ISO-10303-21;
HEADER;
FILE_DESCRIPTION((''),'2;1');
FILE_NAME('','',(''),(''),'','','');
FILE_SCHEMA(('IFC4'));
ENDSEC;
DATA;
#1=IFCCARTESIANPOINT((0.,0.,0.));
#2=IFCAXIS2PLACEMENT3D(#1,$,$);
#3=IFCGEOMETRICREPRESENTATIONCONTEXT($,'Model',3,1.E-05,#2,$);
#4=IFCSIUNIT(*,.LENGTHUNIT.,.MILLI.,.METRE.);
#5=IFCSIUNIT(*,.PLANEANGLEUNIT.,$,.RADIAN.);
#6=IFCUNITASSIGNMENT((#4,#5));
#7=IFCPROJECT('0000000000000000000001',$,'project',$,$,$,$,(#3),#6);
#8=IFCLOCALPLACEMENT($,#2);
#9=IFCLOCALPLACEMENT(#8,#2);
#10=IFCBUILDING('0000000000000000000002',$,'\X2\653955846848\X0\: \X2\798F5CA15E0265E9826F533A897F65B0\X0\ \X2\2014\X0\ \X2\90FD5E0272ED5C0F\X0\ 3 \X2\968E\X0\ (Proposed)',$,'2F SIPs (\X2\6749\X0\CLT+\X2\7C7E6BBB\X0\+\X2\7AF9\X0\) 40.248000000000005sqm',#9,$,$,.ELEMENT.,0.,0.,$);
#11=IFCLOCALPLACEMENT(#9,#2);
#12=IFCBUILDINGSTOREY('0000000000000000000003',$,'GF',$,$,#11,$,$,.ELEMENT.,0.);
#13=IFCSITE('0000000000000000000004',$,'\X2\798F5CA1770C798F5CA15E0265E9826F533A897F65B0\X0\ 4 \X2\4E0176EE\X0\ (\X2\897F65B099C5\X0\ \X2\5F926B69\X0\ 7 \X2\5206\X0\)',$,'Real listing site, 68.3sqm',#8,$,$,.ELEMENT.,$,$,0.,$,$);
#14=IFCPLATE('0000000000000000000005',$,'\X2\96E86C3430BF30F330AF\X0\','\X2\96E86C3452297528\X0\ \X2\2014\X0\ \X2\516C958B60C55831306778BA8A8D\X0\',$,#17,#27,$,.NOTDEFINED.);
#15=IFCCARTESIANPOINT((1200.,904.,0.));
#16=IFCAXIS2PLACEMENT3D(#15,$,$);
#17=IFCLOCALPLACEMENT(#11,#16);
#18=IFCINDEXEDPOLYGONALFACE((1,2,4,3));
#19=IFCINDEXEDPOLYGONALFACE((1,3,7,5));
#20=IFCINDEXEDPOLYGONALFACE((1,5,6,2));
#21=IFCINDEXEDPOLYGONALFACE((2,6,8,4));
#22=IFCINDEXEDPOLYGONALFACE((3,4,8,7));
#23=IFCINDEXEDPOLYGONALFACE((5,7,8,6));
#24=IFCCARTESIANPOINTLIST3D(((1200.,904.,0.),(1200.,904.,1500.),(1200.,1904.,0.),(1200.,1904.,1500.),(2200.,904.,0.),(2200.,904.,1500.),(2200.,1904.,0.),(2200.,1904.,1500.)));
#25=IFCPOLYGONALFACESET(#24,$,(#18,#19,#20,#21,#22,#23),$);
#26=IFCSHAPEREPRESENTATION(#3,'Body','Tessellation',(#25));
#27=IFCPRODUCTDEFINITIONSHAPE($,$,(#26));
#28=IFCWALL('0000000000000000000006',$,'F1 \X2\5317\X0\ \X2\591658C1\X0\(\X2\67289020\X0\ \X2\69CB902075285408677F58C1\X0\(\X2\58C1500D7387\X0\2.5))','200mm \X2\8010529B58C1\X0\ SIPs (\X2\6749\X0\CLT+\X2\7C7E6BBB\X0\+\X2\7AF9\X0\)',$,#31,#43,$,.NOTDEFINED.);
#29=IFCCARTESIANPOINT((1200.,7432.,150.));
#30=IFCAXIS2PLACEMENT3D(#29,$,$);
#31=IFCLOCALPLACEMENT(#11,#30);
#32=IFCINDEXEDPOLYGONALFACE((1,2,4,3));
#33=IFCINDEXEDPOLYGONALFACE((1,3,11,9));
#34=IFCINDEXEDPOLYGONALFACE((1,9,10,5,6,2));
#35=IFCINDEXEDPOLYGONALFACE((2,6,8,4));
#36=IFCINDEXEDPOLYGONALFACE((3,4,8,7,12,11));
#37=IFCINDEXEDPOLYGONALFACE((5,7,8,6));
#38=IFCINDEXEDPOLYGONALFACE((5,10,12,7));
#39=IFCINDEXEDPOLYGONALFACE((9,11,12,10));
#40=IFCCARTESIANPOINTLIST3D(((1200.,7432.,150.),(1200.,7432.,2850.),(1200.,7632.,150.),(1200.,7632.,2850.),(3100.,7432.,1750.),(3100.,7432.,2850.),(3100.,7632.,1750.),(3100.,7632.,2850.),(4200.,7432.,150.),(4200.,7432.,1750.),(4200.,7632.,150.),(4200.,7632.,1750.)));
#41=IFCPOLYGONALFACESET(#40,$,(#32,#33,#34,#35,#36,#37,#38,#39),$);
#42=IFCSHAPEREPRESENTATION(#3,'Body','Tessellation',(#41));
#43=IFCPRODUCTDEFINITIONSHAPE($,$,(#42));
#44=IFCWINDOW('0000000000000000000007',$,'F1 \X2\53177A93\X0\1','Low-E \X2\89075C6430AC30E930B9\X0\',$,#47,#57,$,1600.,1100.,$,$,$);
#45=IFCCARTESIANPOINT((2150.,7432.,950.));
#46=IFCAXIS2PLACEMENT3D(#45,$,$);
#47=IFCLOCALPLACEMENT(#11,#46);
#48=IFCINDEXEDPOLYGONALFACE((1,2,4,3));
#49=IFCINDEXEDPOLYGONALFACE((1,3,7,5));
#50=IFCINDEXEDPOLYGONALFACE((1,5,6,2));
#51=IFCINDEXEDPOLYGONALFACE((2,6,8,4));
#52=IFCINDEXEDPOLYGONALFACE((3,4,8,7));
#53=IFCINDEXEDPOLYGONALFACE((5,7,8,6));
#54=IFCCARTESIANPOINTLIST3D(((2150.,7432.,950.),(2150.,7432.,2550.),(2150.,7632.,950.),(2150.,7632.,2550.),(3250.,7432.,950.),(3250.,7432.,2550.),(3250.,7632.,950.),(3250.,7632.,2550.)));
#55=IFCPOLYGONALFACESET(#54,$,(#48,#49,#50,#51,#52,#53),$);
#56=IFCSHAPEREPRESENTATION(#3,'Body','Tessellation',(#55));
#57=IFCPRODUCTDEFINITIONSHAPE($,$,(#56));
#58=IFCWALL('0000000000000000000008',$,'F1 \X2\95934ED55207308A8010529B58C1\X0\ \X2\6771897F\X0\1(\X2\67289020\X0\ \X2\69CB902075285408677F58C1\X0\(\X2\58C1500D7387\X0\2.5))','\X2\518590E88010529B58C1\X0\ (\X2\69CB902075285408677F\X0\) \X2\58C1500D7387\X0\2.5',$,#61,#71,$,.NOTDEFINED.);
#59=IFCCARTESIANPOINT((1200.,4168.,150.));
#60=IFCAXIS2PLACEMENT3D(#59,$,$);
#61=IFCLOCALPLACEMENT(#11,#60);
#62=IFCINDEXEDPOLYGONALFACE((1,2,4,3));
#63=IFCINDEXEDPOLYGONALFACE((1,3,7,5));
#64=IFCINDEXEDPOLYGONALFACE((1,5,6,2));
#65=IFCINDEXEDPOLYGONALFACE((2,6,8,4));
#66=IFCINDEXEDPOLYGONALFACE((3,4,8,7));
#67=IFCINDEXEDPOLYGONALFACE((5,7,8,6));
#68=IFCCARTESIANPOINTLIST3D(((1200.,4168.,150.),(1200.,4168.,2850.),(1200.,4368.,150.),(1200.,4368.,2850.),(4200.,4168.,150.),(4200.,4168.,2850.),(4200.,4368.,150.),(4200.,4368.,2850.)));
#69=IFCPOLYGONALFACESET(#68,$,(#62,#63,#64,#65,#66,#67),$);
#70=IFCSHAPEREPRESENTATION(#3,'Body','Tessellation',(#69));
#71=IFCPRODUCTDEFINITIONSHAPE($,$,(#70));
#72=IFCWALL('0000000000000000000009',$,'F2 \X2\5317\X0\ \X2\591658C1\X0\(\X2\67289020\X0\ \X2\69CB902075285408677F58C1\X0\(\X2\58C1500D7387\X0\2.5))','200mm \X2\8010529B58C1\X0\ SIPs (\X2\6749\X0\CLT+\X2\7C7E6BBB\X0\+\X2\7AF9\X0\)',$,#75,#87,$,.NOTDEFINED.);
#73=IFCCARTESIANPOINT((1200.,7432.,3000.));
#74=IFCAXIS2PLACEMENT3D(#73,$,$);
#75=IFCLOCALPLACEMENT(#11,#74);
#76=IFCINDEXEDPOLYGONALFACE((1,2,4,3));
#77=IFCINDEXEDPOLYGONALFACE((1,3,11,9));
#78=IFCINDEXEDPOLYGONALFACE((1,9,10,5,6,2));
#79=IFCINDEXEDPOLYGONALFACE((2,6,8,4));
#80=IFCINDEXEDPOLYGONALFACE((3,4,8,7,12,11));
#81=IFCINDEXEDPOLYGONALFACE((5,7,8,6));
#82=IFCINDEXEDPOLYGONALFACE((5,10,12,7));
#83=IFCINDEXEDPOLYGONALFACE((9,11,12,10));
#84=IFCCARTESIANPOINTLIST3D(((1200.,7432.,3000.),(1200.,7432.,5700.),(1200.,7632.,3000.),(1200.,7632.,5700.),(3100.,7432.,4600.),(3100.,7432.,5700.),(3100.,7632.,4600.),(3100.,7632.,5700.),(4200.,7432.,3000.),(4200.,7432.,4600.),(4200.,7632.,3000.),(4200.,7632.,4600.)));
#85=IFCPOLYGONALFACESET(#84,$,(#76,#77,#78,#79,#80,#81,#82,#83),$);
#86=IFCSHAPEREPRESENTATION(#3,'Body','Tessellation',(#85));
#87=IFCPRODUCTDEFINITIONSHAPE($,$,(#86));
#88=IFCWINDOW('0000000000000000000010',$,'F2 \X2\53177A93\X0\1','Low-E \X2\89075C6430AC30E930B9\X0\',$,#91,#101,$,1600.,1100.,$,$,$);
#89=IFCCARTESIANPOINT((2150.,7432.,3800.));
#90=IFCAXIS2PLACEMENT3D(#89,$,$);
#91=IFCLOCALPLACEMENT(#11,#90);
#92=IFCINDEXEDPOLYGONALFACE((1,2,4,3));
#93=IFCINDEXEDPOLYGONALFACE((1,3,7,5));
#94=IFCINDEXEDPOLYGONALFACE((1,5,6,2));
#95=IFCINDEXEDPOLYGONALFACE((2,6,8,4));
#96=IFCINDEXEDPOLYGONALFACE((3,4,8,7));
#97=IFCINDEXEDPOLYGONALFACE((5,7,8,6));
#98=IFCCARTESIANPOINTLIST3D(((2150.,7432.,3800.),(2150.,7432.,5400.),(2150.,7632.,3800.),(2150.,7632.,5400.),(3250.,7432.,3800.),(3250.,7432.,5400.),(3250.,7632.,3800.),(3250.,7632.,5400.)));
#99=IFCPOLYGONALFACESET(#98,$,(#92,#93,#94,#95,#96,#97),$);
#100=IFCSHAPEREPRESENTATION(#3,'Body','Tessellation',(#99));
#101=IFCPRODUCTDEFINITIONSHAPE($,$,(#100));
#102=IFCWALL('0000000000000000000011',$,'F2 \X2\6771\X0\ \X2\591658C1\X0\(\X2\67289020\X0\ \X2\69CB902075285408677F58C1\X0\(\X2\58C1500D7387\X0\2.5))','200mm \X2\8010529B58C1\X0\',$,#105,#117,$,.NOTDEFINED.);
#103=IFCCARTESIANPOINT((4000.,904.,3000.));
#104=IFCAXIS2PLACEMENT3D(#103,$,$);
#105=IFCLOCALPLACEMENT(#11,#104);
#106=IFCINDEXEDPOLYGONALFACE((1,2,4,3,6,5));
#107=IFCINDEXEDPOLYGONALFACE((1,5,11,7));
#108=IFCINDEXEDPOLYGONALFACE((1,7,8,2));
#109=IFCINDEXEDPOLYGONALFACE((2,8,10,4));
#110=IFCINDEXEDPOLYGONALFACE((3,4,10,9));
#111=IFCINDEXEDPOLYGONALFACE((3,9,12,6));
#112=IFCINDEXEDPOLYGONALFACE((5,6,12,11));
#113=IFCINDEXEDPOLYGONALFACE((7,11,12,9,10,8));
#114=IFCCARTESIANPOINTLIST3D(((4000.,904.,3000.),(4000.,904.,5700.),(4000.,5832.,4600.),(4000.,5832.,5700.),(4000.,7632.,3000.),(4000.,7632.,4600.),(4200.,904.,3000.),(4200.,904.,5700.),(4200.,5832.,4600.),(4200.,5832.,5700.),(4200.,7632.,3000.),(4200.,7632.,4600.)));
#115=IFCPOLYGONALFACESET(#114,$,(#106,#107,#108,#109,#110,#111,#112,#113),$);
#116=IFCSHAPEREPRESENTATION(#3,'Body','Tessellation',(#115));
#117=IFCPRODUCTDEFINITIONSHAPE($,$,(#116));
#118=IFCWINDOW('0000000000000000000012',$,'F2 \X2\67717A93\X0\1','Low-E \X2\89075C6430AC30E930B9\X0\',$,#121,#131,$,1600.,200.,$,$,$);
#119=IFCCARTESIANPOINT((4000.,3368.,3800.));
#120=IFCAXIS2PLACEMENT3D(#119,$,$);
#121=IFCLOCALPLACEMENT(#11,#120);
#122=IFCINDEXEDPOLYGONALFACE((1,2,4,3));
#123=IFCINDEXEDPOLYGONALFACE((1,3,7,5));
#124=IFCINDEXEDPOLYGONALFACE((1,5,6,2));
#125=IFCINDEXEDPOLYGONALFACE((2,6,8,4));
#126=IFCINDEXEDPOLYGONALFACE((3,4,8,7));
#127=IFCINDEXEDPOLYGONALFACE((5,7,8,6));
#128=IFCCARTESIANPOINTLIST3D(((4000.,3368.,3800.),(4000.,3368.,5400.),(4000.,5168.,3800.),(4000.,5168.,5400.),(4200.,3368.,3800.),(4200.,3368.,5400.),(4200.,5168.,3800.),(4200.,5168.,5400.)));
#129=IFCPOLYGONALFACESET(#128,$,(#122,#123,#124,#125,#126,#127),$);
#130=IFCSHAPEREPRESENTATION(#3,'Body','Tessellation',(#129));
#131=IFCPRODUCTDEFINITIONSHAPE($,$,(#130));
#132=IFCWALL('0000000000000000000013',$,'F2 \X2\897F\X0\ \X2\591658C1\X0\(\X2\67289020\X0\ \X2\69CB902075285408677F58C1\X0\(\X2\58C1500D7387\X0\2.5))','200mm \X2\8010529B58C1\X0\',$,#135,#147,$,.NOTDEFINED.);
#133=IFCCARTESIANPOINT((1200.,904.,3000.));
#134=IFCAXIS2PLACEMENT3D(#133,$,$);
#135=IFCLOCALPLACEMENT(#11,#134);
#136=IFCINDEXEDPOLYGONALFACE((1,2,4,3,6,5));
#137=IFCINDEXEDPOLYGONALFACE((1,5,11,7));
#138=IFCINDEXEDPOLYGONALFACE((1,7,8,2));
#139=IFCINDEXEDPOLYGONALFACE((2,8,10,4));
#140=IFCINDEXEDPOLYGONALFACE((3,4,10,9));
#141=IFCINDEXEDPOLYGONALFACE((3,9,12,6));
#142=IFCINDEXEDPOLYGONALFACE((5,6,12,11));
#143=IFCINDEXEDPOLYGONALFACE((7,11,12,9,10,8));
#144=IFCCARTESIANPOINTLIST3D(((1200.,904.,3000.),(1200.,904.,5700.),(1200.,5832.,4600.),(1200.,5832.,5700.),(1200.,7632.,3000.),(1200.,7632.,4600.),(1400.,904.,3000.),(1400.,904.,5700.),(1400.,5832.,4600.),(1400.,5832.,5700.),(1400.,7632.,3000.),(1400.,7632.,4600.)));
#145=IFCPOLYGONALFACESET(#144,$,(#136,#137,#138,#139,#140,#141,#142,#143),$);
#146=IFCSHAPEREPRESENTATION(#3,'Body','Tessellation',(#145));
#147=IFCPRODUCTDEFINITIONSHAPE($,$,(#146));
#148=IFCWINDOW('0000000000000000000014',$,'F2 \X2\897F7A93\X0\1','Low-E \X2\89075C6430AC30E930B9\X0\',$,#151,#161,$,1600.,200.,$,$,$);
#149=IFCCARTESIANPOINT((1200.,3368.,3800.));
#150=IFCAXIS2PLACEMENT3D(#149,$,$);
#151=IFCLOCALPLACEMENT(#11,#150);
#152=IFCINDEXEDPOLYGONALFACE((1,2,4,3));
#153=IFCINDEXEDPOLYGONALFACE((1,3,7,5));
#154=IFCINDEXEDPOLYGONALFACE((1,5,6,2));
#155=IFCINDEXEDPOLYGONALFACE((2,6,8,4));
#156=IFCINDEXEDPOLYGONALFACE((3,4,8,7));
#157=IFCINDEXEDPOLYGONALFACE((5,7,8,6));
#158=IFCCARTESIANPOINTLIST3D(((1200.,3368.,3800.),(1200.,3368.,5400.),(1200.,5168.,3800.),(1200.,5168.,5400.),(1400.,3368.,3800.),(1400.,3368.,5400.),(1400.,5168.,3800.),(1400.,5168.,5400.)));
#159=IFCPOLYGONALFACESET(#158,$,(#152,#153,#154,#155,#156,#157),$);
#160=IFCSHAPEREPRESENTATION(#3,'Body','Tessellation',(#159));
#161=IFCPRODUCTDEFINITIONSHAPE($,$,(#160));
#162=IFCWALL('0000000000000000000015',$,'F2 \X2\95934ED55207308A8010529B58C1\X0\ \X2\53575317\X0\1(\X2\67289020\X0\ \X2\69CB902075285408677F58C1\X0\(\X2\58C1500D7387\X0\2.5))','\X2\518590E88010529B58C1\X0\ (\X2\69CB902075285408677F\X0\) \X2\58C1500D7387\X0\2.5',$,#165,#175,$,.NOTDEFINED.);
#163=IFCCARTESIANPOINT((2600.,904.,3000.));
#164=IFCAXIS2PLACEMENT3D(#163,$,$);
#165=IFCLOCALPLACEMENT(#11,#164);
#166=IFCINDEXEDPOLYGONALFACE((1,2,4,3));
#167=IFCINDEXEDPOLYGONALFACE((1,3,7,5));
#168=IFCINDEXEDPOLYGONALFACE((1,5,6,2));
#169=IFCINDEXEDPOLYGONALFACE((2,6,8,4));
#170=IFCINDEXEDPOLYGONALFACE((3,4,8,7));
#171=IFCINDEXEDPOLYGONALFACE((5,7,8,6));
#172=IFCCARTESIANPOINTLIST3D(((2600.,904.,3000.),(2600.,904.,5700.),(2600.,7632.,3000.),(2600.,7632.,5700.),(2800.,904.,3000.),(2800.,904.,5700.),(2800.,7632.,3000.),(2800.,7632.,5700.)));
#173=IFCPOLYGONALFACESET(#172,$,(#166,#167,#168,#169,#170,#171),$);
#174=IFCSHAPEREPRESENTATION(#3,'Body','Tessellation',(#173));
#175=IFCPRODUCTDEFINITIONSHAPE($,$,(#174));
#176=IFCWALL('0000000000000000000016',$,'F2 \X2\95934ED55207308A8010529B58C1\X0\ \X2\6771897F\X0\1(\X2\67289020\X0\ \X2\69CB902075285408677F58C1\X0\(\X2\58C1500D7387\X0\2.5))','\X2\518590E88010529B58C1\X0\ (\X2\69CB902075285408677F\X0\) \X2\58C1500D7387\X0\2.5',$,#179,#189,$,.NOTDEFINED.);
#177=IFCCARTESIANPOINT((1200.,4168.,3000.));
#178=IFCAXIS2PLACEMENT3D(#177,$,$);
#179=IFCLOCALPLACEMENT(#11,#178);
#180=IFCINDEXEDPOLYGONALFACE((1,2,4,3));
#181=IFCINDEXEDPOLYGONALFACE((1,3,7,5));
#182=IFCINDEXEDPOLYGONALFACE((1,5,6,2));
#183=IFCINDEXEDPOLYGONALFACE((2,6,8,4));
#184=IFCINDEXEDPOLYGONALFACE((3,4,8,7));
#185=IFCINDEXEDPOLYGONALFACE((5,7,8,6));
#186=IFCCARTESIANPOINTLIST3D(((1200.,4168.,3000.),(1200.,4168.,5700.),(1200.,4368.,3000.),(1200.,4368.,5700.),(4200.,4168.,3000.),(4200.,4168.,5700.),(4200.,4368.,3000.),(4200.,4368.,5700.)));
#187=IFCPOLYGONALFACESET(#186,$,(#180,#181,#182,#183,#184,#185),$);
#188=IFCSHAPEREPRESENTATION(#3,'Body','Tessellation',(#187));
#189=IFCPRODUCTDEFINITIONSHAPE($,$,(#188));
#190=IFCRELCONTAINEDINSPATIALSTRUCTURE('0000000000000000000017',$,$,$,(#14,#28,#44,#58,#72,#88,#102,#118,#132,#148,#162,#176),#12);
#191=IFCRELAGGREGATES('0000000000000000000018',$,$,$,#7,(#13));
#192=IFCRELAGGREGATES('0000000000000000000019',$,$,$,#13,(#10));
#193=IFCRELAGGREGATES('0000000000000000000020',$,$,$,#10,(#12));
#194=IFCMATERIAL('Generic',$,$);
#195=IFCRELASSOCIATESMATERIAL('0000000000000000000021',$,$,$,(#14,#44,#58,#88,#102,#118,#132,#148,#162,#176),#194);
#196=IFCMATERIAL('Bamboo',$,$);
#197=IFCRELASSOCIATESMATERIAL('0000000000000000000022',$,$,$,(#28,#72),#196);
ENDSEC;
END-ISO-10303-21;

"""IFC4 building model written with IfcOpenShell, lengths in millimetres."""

from ifc_helpers import new_model, si_unit, frame, frame_2d, origin, place, context, project, spatial, rectangle, extrude, material, element, fill, save


model = new_model("IFC4")

# Units and contexts
model_context = context("Model", 3, precision=1e-05, world=origin())
ifc_project = project(units=[si_unit("LENGTHUNIT", "METRE", prefix="MILLI"), si_unit("PLANEANGLEUNIT", "RADIAN")], contexts=[model_context])

# Site, building, storey
site_placement = place(None, origin())
site = spatial("IfcSite", under=ifc_project, at=site_placement, Name="福岡県福岡市早良区西新 4 丁目 (西新駅 徒歩 7 分)", ObjectType="Real listing site, 68.3sqm", CompositionType="ELEMENT", RefElevation=0.0)
building_placement = place(site_placement, origin())
building = spatial("IfcBuilding", under=site, at=building_placement, Name="改善案: 福岡市早良区西新 — 都市狭小 3 階 (Proposed)", ObjectType="2F SIPs (杉CLT+籾殻+竹) 40.248000000000005sqm", CompositionType="ELEMENT", ElevationOfRefHeight=0.0, ElevationOfTerrain=0.0)
storey_placement = place(building_placement, origin())
storey = spatial("IfcBuildingStorey", under=building, at=storey_placement, Name="GF", CompositionType="ELEMENT", Elevation=0.0)

# Plate
ifc_material_1 = material(Name="Generic")
plate_placement = place(storey_placement, frame((1200.0, 904.0, 0.0)))
element("IfcPlate", 1, at=plate_placement, inside=storey, material=ifc_material_1, Name="雨水タンク", Description="雨水利用 — 公開情報で確認", PredefinedType="NOTDEFINED", context=model_context, shape_type="SweptSolid", body=[
    extrude(rectangle(XDim=1000.0, YDim=1000.0, at=frame_2d((500.0, 500.0))), frame((1200.0, 904.0, 0.0)), (0.0, 0.0, 1.0), 1500.0),
])

# Wall, opening, window
ifc_material_2 = material(Name="Bamboo")
wall_1_placement = place(storey_placement, frame((1200.0, 7432.0, 150.0)))
wall_1 = element("IfcWall", 2, at=wall_1_placement, inside=storey, material=ifc_material_2, Name="F1 北 外壁(木造 構造用合板壁(壁倍率2.5))", Description="200mm 耐力壁 SIPs (杉CLT+籾殻+竹)", PredefinedType="NOTDEFINED", context=model_context, shape_type="SweptSolid", body=[
    extrude(rectangle(XDim=3000.0, YDim=200.0, at=frame_2d((1500.0, 100.0))), frame((1200.0, 7432.0, 150.0)), (0.0, 0.0, 1.0), 2700.0),
])
opening_1_placement = place(storey_placement, frame((2150.0, 7432.0, 950.0)))
opening_1 = element("IfcOpeningElement", 3, at=opening_1_placement, cuts=wall_1, PredefinedType="NOTDEFINED", context=model_context, shape_type="SweptSolid", body=[
    extrude(rectangle(XDim=1100.0, YDim=200.0, at=frame_2d((550.0, 100.0))), frame((2150.0, 7432.0, 950.0)), (0.0, 0.0, 1.0), 1600.0),
])
window_1_placement = place(storey_placement, frame((2150.0, 7432.0, 950.0)))
window_1 = element("IfcWindow", 4, at=window_1_placement, inside=storey, material=ifc_material_1, Name="F1 北窓1", Description="Low-E 複層ガラス", OverallHeight=1600.0, OverallWidth=1100.0, context=model_context, shape_type="SweptSolid", body=[
    extrude(rectangle(XDim=1100.0, YDim=200.0, at=frame_2d((550.0, 100.0))), frame((2150.0, 7432.0, 950.0)), (0.0, 0.0, 1.0), 1600.0),
])
fill(opening_1, window_1)

# Wall
wall_2_placement = place(storey_placement, frame((1200.0, 4168.0, 150.0)))
element("IfcWall", 5, at=wall_2_placement, inside=storey, material=ifc_material_1, Name="F1 間仕切り耐力壁 東西1(木造 構造用合板壁(壁倍率2.5))", Description="内部耐力壁 (構造用合板) 壁倍率2.5", PredefinedType="NOTDEFINED", context=model_context, shape_type="SweptSolid", body=[
    extrude(rectangle(XDim=3000.0, YDim=200.0, at=frame_2d((1500.0, 100.0))), frame((1200.0, 4168.0, 150.0)), (0.0, 0.0, 1.0), 2700.0),
])

# Walls, openings, windows
wall_3_placement = place(storey_placement, frame((1200.0, 7432.0, 3000.0)))
wall_3 = element("IfcWall", 6, at=wall_3_placement, inside=storey, material=ifc_material_2, Name="F2 北 外壁(木造 構造用合板壁(壁倍率2.5))", Description="200mm 耐力壁 SIPs (杉CLT+籾殻+竹)", PredefinedType="NOTDEFINED", context=model_context, shape_type="SweptSolid", body=[
    extrude(rectangle(XDim=3000.0, YDim=200.0, at=frame_2d((1500.0, 100.0))), frame((1200.0, 7432.0, 3000.0)), (0.0, 0.0, 1.0), 2700.0),
])
opening_2_placement = place(storey_placement, frame((2150.0, 7432.0, 3800.0)))
opening_2 = element("IfcOpeningElement", 7, at=opening_2_placement, cuts=wall_3, PredefinedType="NOTDEFINED", context=model_context, shape_type="SweptSolid", body=[
    extrude(rectangle(XDim=1100.0, YDim=200.0, at=frame_2d((550.0, 100.0))), frame((2150.0, 7432.0, 3800.0)), (0.0, 0.0, 1.0), 1600.0),
])
window_2_placement = place(storey_placement, frame((2150.0, 7432.0, 3800.0)))
window_2 = element("IfcWindow", 8, at=window_2_placement, inside=storey, material=ifc_material_1, Name="F2 北窓1", Description="Low-E 複層ガラス", OverallHeight=1600.0, OverallWidth=1100.0, context=model_context, shape_type="SweptSolid", body=[
    extrude(rectangle(XDim=1100.0, YDim=200.0, at=frame_2d((550.0, 100.0))), frame((2150.0, 7432.0, 3800.0)), (0.0, 0.0, 1.0), 1600.0),
])
fill(opening_2, window_2)
wall_4_placement = place(storey_placement, frame((4000.0, 904.0, 3000.0)))
wall_4 = element("IfcWall", 9, at=wall_4_placement, inside=storey, material=ifc_material_1, Name="F2 東 外壁(木造 構造用合板壁(壁倍率2.5))", Description="200mm 耐力壁", PredefinedType="NOTDEFINED", context=model_context, shape_type="SweptSolid", body=[
    extrude(rectangle(XDim=200.0, YDim=6728.0, at=frame_2d((100.0, 3364.0))), frame((4000.0, 904.0, 3000.0)), (0.0, 0.0, 1.0), 2700.0),
])
opening_3_placement = place(storey_placement, frame((4000.0, 3368.0, 3800.0)))
opening_3 = element("IfcOpeningElement", 10, at=opening_3_placement, cuts=wall_4, PredefinedType="NOTDEFINED", context=model_context, shape_type="SweptSolid", body=[
    extrude(rectangle(XDim=200.0, YDim=1800.0, at=frame_2d((100.0, 900.0))), frame((4000.0, 3368.0, 3800.0)), (0.0, 0.0, 1.0), 1600.0),
])
window_3_placement = place(storey_placement, frame((4000.0, 3368.0, 3800.0)))
window_3 = element("IfcWindow", 11, at=window_3_placement, inside=storey, material=ifc_material_1, Name="F2 東窓1", Description="Low-E 複層ガラス", OverallHeight=1600.0, OverallWidth=200.0, context=model_context, shape_type="SweptSolid", body=[
    extrude(rectangle(XDim=200.0, YDim=1800.0, at=frame_2d((100.0, 900.0))), frame((4000.0, 3368.0, 3800.0)), (0.0, 0.0, 1.0), 1600.0),
])
fill(opening_3, window_3)
wall_5_placement = place(storey_placement, frame((1200.0, 904.0, 3000.0)))
wall_5 = element("IfcWall", 12, at=wall_5_placement, inside=storey, material=ifc_material_1, Name="F2 西 外壁(木造 構造用合板壁(壁倍率2.5))", Description="200mm 耐力壁", PredefinedType="NOTDEFINED", context=model_context, shape_type="SweptSolid", body=[
    extrude(rectangle(XDim=200.0, YDim=6728.0, at=frame_2d((100.0, 3364.0))), frame((1200.0, 904.0, 3000.0)), (0.0, 0.0, 1.0), 2700.0),
])
opening_4_placement = place(storey_placement, frame((1200.0, 3368.0, 3800.0)))
opening_4 = element("IfcOpeningElement", 13, at=opening_4_placement, cuts=wall_5, PredefinedType="NOTDEFINED", context=model_context, shape_type="SweptSolid", body=[
    extrude(rectangle(XDim=200.0, YDim=1800.0, at=frame_2d((100.0, 900.0))), frame((1200.0, 3368.0, 3800.0)), (0.0, 0.0, 1.0), 1600.0),
])
window_4_placement = place(storey_placement, frame((1200.0, 3368.0, 3800.0)))
window_4 = element("IfcWindow", 14, at=window_4_placement, inside=storey, material=ifc_material_1, Name="F2 西窓1", Description="Low-E 複層ガラス", OverallHeight=1600.0, OverallWidth=200.0, context=model_context, shape_type="SweptSolid", body=[
    extrude(rectangle(XDim=200.0, YDim=1800.0, at=frame_2d((100.0, 900.0))), frame((1200.0, 3368.0, 3800.0)), (0.0, 0.0, 1.0), 1600.0),
])
fill(opening_4, window_4)

# Walls
wall_6_placement = place(storey_placement, frame((2600.0, 904.0, 3000.0)))
element("IfcWall", 15, at=wall_6_placement, inside=storey, material=ifc_material_1, Name="F2 間仕切り耐力壁 南北1(木造 構造用合板壁(壁倍率2.5))", Description="内部耐力壁 (構造用合板) 壁倍率2.5", PredefinedType="NOTDEFINED", context=model_context, shape_type="SweptSolid", body=[
    extrude(rectangle(XDim=200.0, YDim=6728.0, at=frame_2d((100.0, 3364.0))), frame((2600.0, 904.0, 3000.0)), (0.0, 0.0, 1.0), 2700.0),
])
wall_7_placement = place(storey_placement, frame((1200.0, 4168.0, 3000.0)))
element("IfcWall", 16, at=wall_7_placement, inside=storey, material=ifc_material_1, Name="F2 間仕切り耐力壁 東西1(木造 構造用合板壁(壁倍率2.5))", Description="内部耐力壁 (構造用合板) 壁倍率2.5", PredefinedType="NOTDEFINED", context=model_context, shape_type="SweptSolid", body=[
    extrude(rectangle(XDim=3000.0, YDim=200.0, at=frame_2d((1500.0, 100.0))), frame((1200.0, 4168.0, 3000.0)), (0.0, 0.0, 1.0), 2700.0),
])

save(model, "model.ifc")
